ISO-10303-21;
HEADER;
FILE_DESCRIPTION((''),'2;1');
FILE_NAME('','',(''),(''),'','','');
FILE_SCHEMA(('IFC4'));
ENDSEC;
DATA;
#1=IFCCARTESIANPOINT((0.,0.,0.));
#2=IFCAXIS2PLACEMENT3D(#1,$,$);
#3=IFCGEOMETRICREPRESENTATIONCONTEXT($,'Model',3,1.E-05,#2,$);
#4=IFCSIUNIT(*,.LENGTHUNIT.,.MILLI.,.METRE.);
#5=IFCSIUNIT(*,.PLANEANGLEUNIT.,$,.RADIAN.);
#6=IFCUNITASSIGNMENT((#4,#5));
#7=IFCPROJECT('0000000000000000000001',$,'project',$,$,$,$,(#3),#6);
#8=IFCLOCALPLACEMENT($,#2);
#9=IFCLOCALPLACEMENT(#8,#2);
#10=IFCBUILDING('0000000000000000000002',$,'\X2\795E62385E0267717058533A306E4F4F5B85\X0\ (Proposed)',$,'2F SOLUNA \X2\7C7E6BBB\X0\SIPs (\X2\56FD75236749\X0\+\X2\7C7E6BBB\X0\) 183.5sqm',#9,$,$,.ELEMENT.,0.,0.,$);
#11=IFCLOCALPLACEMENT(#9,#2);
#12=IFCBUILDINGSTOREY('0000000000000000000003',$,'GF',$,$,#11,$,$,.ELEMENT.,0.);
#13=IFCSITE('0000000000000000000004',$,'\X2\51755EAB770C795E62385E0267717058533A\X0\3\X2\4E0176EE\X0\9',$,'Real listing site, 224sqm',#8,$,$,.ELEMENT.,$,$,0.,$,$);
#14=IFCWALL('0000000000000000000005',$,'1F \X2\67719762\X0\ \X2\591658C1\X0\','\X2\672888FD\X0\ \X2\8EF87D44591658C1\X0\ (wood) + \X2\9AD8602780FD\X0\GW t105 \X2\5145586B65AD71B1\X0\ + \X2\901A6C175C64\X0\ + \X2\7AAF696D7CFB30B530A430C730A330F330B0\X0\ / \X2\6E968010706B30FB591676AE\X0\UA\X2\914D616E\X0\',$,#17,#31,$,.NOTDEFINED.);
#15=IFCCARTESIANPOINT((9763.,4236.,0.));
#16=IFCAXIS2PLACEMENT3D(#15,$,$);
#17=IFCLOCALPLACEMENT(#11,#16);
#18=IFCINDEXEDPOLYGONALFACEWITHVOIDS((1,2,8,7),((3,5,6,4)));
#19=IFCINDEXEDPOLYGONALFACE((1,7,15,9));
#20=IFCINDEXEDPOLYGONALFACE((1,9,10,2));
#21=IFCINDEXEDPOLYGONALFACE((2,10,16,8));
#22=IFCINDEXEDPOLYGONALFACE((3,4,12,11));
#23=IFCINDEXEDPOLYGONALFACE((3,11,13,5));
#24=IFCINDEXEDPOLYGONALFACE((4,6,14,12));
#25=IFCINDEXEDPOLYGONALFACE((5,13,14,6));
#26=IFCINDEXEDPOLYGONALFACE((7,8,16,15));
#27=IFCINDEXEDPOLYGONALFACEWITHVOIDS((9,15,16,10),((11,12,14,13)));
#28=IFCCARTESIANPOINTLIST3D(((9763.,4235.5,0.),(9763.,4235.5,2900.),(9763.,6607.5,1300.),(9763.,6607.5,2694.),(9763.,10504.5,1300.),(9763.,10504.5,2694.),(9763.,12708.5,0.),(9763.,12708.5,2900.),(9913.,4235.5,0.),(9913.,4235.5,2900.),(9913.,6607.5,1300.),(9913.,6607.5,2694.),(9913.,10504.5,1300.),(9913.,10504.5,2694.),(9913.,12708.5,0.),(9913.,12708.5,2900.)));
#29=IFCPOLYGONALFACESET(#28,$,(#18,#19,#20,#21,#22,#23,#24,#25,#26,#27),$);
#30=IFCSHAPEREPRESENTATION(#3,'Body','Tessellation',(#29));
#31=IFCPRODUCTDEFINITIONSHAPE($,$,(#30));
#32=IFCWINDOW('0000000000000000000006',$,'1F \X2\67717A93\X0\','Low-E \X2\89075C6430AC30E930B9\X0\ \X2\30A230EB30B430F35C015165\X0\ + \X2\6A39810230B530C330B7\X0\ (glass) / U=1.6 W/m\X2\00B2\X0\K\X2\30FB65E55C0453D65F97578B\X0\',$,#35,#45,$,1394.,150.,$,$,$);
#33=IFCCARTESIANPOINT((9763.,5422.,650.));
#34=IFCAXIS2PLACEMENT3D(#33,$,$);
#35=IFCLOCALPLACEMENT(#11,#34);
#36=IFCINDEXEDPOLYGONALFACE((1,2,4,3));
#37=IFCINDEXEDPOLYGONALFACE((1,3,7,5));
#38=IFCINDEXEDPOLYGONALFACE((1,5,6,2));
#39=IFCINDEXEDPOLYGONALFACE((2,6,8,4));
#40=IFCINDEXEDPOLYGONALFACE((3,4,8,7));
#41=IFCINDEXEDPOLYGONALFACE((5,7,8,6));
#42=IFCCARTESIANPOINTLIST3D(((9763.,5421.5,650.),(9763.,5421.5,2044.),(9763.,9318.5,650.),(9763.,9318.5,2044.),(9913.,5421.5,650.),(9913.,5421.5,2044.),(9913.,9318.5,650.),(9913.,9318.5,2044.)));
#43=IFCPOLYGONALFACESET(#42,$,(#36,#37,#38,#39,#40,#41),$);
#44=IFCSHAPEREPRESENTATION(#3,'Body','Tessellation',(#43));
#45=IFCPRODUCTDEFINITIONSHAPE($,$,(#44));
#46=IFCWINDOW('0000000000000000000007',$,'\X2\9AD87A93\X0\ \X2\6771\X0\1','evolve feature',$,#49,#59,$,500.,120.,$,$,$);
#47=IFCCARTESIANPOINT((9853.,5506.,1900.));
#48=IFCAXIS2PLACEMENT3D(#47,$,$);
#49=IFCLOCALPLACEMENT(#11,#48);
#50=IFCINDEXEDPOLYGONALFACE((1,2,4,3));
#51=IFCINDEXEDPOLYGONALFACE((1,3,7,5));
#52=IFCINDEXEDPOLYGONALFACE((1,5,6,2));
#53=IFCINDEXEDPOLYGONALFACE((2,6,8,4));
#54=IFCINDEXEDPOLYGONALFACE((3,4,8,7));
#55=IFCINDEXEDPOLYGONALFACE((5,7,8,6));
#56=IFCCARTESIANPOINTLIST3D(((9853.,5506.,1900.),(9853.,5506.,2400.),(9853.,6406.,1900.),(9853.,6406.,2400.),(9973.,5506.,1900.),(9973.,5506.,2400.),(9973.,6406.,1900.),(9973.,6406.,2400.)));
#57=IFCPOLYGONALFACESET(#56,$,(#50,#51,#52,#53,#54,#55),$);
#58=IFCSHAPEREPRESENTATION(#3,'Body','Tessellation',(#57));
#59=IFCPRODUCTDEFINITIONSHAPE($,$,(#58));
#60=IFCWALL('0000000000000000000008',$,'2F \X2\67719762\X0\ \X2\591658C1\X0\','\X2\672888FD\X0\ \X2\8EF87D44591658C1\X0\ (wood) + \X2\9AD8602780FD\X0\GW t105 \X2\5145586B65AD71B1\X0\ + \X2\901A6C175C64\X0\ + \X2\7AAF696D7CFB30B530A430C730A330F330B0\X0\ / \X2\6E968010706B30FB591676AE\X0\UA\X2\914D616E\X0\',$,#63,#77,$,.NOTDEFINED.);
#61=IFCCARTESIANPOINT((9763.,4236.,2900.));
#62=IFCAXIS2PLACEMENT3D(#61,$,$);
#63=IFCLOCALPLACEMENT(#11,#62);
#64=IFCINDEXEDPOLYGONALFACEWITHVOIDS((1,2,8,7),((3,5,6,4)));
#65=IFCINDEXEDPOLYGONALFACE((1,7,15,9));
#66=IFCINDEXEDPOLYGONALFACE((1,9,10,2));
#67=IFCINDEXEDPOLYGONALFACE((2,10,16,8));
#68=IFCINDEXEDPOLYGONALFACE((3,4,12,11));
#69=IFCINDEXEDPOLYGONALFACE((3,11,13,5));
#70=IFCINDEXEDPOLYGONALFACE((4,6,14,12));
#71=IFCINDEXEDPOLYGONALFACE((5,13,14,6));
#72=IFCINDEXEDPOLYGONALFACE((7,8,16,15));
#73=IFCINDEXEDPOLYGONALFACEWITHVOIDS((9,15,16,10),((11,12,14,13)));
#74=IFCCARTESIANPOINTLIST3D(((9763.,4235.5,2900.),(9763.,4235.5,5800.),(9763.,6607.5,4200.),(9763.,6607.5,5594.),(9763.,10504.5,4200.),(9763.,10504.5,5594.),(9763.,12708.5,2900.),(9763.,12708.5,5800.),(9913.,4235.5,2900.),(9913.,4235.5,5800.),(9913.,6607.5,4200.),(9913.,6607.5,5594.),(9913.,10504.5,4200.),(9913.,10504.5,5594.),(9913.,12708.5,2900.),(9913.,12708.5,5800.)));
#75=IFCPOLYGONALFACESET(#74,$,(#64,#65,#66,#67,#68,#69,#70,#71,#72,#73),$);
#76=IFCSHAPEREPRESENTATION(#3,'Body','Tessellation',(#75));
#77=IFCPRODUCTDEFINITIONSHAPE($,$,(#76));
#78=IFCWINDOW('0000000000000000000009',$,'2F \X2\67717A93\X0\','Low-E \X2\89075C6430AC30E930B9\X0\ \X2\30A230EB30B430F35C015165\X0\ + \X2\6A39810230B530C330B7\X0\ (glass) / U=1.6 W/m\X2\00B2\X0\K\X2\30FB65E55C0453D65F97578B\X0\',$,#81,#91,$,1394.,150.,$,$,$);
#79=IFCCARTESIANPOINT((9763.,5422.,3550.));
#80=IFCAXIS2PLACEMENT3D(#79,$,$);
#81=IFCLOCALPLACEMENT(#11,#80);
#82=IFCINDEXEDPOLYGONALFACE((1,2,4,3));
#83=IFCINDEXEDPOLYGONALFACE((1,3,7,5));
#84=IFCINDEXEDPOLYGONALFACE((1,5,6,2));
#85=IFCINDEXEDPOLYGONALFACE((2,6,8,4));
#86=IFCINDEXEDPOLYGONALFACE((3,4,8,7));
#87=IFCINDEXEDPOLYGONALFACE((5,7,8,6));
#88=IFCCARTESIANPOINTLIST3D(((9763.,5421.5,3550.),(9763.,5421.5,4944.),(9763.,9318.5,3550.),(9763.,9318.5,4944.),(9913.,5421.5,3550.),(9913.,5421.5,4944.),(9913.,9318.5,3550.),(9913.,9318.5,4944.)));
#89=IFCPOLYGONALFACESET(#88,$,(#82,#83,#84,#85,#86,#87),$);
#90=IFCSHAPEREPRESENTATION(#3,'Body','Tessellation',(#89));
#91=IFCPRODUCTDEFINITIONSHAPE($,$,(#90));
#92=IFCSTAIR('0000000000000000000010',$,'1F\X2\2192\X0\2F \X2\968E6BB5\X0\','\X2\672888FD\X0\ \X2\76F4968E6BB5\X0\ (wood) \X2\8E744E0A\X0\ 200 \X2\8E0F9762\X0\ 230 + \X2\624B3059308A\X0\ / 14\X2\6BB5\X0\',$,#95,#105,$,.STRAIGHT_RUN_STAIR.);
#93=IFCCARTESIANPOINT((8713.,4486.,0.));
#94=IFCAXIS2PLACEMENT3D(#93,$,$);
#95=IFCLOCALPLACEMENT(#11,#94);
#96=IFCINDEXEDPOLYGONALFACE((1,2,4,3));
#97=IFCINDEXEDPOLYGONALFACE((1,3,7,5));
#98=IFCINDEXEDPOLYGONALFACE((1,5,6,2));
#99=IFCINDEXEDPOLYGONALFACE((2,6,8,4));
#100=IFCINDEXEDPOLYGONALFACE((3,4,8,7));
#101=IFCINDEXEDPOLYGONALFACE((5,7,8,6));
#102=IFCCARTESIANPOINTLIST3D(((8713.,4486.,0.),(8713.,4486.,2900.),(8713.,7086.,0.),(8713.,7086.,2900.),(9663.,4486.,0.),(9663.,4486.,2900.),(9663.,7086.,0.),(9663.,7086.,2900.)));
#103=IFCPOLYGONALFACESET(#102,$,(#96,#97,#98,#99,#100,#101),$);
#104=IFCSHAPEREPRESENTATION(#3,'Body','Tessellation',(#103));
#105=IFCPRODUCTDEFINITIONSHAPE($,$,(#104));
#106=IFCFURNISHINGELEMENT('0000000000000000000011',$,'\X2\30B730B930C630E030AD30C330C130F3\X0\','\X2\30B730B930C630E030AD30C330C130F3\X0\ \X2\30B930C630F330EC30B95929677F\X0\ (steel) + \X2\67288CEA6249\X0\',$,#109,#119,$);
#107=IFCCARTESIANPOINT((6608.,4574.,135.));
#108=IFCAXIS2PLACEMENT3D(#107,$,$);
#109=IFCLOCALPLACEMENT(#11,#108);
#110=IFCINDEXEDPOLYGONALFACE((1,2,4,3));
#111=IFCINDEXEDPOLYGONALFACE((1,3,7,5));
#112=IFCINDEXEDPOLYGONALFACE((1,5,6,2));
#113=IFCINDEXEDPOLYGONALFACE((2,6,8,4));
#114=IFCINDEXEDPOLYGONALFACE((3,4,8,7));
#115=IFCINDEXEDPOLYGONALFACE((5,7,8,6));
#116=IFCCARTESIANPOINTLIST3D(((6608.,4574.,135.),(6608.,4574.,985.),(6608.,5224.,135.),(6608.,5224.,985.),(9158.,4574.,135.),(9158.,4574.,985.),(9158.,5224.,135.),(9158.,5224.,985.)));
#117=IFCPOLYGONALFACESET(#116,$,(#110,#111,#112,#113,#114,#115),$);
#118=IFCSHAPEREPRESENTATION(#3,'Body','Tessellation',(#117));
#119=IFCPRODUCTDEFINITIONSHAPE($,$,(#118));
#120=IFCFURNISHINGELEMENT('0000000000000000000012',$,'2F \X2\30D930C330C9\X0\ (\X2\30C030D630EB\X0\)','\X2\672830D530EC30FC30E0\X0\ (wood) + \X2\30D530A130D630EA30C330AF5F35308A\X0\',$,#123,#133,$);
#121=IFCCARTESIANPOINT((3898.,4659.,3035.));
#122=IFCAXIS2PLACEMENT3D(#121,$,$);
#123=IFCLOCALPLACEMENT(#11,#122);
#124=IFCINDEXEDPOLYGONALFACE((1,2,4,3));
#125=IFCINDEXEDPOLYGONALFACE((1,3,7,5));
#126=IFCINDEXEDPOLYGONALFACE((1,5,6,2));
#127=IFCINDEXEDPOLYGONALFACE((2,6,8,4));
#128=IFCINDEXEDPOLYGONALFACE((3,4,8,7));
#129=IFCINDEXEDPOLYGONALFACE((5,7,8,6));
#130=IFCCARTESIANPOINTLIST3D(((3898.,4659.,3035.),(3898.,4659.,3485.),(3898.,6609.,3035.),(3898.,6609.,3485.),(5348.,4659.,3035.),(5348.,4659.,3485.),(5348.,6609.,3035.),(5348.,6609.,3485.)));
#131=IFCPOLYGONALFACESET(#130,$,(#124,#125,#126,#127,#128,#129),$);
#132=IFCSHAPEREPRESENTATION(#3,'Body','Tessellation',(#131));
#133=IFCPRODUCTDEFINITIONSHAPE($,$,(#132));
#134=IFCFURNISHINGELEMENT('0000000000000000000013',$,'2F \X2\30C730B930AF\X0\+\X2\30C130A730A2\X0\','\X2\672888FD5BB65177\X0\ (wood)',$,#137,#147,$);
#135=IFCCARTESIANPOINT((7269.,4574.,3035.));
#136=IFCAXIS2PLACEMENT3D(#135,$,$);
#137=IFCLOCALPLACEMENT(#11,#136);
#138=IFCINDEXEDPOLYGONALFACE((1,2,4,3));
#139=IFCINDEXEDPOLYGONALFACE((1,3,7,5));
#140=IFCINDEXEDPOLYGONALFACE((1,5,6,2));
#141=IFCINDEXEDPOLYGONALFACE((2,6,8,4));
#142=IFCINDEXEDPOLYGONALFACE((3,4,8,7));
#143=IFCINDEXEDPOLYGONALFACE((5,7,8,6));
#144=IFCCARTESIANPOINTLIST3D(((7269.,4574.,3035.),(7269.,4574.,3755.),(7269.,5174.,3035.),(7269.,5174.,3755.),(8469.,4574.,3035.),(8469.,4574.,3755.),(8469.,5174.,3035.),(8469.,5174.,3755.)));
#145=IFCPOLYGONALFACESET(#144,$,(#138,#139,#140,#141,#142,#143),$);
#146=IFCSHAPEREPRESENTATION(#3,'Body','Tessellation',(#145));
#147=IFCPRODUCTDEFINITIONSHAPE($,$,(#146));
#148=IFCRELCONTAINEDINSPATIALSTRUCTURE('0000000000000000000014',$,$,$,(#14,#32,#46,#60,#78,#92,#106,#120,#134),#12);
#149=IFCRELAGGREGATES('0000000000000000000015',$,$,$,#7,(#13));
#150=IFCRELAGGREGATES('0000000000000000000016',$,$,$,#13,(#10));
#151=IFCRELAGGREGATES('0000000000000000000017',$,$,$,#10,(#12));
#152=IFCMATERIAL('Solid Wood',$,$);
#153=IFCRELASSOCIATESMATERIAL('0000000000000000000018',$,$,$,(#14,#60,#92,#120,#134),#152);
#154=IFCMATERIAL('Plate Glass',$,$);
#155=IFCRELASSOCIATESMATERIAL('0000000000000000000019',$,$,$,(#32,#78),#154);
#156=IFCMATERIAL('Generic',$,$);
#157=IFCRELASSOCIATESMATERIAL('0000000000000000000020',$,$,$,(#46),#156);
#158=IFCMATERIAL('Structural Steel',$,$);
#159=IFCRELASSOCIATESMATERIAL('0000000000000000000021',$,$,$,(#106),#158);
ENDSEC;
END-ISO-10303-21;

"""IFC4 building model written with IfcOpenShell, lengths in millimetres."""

from ifc_helpers import new_model, si_unit, frame, frame_2d, origin, place, context, project, spatial, rectangle, extrude, material, element, fill, save


model = new_model("IFC4")

# Units and contexts
model_context = context("Model", 3, precision=1e-05, world=origin())
ifc_project = project(units=[si_unit("LENGTHUNIT", "METRE", prefix="MILLI"), si_unit("PLANEANGLEUNIT", "RADIAN")], contexts=[model_context])

# Site, building, storey
site_placement = place(None, origin())
site = spatial("IfcSite", under=ifc_project, at=site_placement, Name="兵庫県神戸市東灘区3丁目9", ObjectType="Real listing site, 224sqm", CompositionType="ELEMENT", RefElevation=0.0)
building_placement = place(site_placement, origin())
building = spatial("IfcBuilding", under=site, at=building_placement, Name="神戸市東灘区の住宅 (Proposed)", ObjectType="2F SOLUNA 籾殻SIPs (国産杉+籾殻) 183.5sqm", CompositionType="ELEMENT", ElevationOfRefHeight=0.0, ElevationOfTerrain=0.0)
storey_placement = place(building_placement, origin())
storey = spatial("IfcBuildingStorey", under=building, at=storey_placement, Name="GF", CompositionType="ELEMENT", Elevation=0.0)

# Shared definitions
ifc_material_1 = material(Name="Solid Wood")

# Wall, openings, windows
wall_1_placement = place(storey_placement, frame((9763.0, 4236.0, 0.0)))
wall_1 = element("IfcWall", 1, at=wall_1_placement, inside=storey, material=ifc_material_1, Name="1F 東面 外壁", Description="木製 軸組外壁 (wood) + 高性能GW t105 充填断熱 + 通気層 + 窯業系サイディング / 準耐火・外皮UA配慮", PredefinedType="NOTDEFINED", context=model_context, shape_type="SweptSolid", body=[
    extrude(rectangle(XDim=150.0, YDim=8473.0, at=frame_2d((75.0, 4236.0))), frame((9763.0, 4236.0, 0.0)), (0.0, 0.0, 1.0), 2900.0),
])
opening_1_placement = place(storey_placement, frame((9763.0, 5422.0, 650.0)))
opening_1 = element("IfcOpeningElement", 2, at=opening_1_placement, cuts=wall_1, PredefinedType="NOTDEFINED", context=model_context, shape_type="SweptSolid", body=[
    extrude(rectangle(XDim=150.0, YDim=3897.0, at=frame_2d((75.0, 1948.0))), frame((9763.0, 5422.0, 650.0)), (0.0, 0.0, 1.0), 1394.0),
])
opening_2_placement = place(storey_placement, frame((9853.0, 5506.0, 1900.0)))
opening_2 = element("IfcOpeningElement", 3, at=opening_2_placement, cuts=wall_1, PredefinedType="NOTDEFINED", context=model_context, shape_type="SweptSolid", body=[
    extrude(rectangle(XDim=120.0, YDim=900.0, at=frame_2d((60.0, 450.0))), frame((9853.0, 5506.0, 1900.0)), (0.0, 0.0, 1.0), 500.0),
])
ifc_material_2 = material(Name="Plate Glass")
window_1_placement = place(storey_placement, frame((9763.0, 5422.0, 650.0)))
window_1 = element("IfcWindow", 4, at=window_1_placement, inside=storey, material=ifc_material_2, Name="1F 東窓", Description="Low-E 複層ガラス アルゴン封入 + 樹脂サッシ (glass) / U=1.6 W/m²K・日射取得型", OverallHeight=1394.0, OverallWidth=150.0, context=model_context, shape_type="SweptSolid", body=[
    extrude(rectangle(XDim=150.0, YDim=3897.0, at=frame_2d((75.0, 1948.0))), frame((9763.0, 5422.0, 650.0)), (0.0, 0.0, 1.0), 1394.0),
])
fill(opening_1, window_1)
ifc_material_3 = material(Name="Generic")
window_2_placement = place(storey_placement, frame((9853.0, 5506.0, 1900.0)))
window_2 = element("IfcWindow", 5, at=window_2_placement, inside=storey, material=ifc_material_3, Name="高窓 東1", Description="evolve feature", OverallHeight=500.0, OverallWidth=120.0, context=model_context, shape_type="SweptSolid", body=[
    extrude(rectangle(XDim=120.0, YDim=900.0, at=frame_2d((60.0, 450.0))), frame((9853.0, 5506.0, 1900.0)), (0.0, 0.0, 1.0), 500.0),
])
fill(opening_2, window_2)

# Wall, opening, window
wall_2_placement = place(storey_placement, frame((9763.0, 4236.0, 2900.0)))
wall_2 = element("IfcWall", 6, at=wall_2_placement, inside=storey, material=ifc_material_1, Name="2F 東面 外壁", Description="木製 軸組外壁 (wood) + 高性能GW t105 充填断熱 + 通気層 + 窯業系サイディング / 準耐火・外皮UA配慮", PredefinedType="NOTDEFINED", context=model_context, shape_type="SweptSolid", body=[
    extrude(rectangle(XDim=150.0, YDim=8473.0, at=frame_2d((75.0, 4236.0))), frame((9763.0, 4236.0, 2900.0)), (0.0, 0.0, 1.0), 2900.0),
])
opening_3_placement = place(storey_placement, frame((9763.0, 5422.0, 3550.0)))
opening_3 = element("IfcOpeningElement", 7, at=opening_3_placement, cuts=wall_2, PredefinedType="NOTDEFINED", context=model_context, shape_type="SweptSolid", body=[
    extrude(rectangle(XDim=150.0, YDim=3897.0, at=frame_2d((75.0, 1948.0))), frame((9763.0, 5422.0, 3550.0)), (0.0, 0.0, 1.0), 1394.0),
])
window_3_placement = place(storey_placement, frame((9763.0, 5422.0, 3550.0)))
window_3 = element("IfcWindow", 8, at=window_3_placement, inside=storey, material=ifc_material_2, Name="2F 東窓", Description="Low-E 複層ガラス アルゴン封入 + 樹脂サッシ (glass) / U=1.6 W/m²K・日射取得型", OverallHeight=1394.0, OverallWidth=150.0, context=model_context, shape_type="SweptSolid", body=[
    extrude(rectangle(XDim=150.0, YDim=3897.0, at=frame_2d((75.0, 1948.0))), frame((9763.0, 5422.0, 3550.0)), (0.0, 0.0, 1.0), 1394.0),
])
fill(opening_3, window_3)

# Stair
stair_placement = place(storey_placement, frame((8713.0, 4486.0, 0.0)))
element("IfcStair", 9, at=stair_placement, inside=storey, material=ifc_material_1, Name="1F→2F 階段", Description="木製 直階段 (wood) 蹴上 200 踏面 230 + 手すり / 14段", PredefinedType="STRAIGHT_RUN_STAIR", context=model_context, shape_type="SweptSolid", body=[
    extrude(rectangle(XDim=950.0, YDim=2600.0, at=frame_2d((475.0, 1300.0))), frame((8713.0, 4486.0, 0.0)), (0.0, 0.0, 1.0), 2900.0),
])

# Furnishing elements
ifc_material_4 = material(Name="Structural Steel")
furnishing_1_placement = place(storey_placement, frame((6608.0, 4574.0, 135.0)))
element("IfcFurnishingElement", 10, at=furnishing_1_placement, inside=storey, material=ifc_material_4, Name="システムキッチン", Description="システムキッチン ステンレス天板 (steel) + 木質扉", context=model_context, shape_type="SweptSolid", body=[
    extrude(rectangle(XDim=2550.0, YDim=650.0, at=frame_2d((1275.0, 325.0))), frame((6608.0, 4574.0, 135.0)), (0.0, 0.0, 1.0), 850.0),
])
furnishing_2_placement = place(storey_placement, frame((3898.0, 4659.0, 3035.0)))
element("IfcFurnishingElement", 11, at=furnishing_2_placement, inside=storey, material=ifc_material_1, Name="2F ベッド (ダブル)", Description="木フレーム (wood) + ファブリック張り", context=model_context, shape_type="SweptSolid", body=[
    extrude(rectangle(XDim=1450.0, YDim=1950.0, at=frame_2d((725.0, 975.0))), frame((3898.0, 4659.0, 3035.0)), (0.0, 0.0, 1.0), 450.0),
])
furnishing_3_placement = place(storey_placement, frame((7269.0, 4574.0, 3035.0)))
element("IfcFurnishingElement", 12, at=furnishing_3_placement, inside=storey, material=ifc_material_1, Name="2F デスク+チェア", Description="木製家具 (wood)", context=model_context, shape_type="SweptSolid", body=[
    extrude(rectangle(XDim=1200.0, YDim=600.0, at=frame_2d((600.0, 300.0))), frame((7269.0, 4574.0, 3035.0)), (0.0, 0.0, 1.0), 720.0),
])

save(model, "model.ifc")
